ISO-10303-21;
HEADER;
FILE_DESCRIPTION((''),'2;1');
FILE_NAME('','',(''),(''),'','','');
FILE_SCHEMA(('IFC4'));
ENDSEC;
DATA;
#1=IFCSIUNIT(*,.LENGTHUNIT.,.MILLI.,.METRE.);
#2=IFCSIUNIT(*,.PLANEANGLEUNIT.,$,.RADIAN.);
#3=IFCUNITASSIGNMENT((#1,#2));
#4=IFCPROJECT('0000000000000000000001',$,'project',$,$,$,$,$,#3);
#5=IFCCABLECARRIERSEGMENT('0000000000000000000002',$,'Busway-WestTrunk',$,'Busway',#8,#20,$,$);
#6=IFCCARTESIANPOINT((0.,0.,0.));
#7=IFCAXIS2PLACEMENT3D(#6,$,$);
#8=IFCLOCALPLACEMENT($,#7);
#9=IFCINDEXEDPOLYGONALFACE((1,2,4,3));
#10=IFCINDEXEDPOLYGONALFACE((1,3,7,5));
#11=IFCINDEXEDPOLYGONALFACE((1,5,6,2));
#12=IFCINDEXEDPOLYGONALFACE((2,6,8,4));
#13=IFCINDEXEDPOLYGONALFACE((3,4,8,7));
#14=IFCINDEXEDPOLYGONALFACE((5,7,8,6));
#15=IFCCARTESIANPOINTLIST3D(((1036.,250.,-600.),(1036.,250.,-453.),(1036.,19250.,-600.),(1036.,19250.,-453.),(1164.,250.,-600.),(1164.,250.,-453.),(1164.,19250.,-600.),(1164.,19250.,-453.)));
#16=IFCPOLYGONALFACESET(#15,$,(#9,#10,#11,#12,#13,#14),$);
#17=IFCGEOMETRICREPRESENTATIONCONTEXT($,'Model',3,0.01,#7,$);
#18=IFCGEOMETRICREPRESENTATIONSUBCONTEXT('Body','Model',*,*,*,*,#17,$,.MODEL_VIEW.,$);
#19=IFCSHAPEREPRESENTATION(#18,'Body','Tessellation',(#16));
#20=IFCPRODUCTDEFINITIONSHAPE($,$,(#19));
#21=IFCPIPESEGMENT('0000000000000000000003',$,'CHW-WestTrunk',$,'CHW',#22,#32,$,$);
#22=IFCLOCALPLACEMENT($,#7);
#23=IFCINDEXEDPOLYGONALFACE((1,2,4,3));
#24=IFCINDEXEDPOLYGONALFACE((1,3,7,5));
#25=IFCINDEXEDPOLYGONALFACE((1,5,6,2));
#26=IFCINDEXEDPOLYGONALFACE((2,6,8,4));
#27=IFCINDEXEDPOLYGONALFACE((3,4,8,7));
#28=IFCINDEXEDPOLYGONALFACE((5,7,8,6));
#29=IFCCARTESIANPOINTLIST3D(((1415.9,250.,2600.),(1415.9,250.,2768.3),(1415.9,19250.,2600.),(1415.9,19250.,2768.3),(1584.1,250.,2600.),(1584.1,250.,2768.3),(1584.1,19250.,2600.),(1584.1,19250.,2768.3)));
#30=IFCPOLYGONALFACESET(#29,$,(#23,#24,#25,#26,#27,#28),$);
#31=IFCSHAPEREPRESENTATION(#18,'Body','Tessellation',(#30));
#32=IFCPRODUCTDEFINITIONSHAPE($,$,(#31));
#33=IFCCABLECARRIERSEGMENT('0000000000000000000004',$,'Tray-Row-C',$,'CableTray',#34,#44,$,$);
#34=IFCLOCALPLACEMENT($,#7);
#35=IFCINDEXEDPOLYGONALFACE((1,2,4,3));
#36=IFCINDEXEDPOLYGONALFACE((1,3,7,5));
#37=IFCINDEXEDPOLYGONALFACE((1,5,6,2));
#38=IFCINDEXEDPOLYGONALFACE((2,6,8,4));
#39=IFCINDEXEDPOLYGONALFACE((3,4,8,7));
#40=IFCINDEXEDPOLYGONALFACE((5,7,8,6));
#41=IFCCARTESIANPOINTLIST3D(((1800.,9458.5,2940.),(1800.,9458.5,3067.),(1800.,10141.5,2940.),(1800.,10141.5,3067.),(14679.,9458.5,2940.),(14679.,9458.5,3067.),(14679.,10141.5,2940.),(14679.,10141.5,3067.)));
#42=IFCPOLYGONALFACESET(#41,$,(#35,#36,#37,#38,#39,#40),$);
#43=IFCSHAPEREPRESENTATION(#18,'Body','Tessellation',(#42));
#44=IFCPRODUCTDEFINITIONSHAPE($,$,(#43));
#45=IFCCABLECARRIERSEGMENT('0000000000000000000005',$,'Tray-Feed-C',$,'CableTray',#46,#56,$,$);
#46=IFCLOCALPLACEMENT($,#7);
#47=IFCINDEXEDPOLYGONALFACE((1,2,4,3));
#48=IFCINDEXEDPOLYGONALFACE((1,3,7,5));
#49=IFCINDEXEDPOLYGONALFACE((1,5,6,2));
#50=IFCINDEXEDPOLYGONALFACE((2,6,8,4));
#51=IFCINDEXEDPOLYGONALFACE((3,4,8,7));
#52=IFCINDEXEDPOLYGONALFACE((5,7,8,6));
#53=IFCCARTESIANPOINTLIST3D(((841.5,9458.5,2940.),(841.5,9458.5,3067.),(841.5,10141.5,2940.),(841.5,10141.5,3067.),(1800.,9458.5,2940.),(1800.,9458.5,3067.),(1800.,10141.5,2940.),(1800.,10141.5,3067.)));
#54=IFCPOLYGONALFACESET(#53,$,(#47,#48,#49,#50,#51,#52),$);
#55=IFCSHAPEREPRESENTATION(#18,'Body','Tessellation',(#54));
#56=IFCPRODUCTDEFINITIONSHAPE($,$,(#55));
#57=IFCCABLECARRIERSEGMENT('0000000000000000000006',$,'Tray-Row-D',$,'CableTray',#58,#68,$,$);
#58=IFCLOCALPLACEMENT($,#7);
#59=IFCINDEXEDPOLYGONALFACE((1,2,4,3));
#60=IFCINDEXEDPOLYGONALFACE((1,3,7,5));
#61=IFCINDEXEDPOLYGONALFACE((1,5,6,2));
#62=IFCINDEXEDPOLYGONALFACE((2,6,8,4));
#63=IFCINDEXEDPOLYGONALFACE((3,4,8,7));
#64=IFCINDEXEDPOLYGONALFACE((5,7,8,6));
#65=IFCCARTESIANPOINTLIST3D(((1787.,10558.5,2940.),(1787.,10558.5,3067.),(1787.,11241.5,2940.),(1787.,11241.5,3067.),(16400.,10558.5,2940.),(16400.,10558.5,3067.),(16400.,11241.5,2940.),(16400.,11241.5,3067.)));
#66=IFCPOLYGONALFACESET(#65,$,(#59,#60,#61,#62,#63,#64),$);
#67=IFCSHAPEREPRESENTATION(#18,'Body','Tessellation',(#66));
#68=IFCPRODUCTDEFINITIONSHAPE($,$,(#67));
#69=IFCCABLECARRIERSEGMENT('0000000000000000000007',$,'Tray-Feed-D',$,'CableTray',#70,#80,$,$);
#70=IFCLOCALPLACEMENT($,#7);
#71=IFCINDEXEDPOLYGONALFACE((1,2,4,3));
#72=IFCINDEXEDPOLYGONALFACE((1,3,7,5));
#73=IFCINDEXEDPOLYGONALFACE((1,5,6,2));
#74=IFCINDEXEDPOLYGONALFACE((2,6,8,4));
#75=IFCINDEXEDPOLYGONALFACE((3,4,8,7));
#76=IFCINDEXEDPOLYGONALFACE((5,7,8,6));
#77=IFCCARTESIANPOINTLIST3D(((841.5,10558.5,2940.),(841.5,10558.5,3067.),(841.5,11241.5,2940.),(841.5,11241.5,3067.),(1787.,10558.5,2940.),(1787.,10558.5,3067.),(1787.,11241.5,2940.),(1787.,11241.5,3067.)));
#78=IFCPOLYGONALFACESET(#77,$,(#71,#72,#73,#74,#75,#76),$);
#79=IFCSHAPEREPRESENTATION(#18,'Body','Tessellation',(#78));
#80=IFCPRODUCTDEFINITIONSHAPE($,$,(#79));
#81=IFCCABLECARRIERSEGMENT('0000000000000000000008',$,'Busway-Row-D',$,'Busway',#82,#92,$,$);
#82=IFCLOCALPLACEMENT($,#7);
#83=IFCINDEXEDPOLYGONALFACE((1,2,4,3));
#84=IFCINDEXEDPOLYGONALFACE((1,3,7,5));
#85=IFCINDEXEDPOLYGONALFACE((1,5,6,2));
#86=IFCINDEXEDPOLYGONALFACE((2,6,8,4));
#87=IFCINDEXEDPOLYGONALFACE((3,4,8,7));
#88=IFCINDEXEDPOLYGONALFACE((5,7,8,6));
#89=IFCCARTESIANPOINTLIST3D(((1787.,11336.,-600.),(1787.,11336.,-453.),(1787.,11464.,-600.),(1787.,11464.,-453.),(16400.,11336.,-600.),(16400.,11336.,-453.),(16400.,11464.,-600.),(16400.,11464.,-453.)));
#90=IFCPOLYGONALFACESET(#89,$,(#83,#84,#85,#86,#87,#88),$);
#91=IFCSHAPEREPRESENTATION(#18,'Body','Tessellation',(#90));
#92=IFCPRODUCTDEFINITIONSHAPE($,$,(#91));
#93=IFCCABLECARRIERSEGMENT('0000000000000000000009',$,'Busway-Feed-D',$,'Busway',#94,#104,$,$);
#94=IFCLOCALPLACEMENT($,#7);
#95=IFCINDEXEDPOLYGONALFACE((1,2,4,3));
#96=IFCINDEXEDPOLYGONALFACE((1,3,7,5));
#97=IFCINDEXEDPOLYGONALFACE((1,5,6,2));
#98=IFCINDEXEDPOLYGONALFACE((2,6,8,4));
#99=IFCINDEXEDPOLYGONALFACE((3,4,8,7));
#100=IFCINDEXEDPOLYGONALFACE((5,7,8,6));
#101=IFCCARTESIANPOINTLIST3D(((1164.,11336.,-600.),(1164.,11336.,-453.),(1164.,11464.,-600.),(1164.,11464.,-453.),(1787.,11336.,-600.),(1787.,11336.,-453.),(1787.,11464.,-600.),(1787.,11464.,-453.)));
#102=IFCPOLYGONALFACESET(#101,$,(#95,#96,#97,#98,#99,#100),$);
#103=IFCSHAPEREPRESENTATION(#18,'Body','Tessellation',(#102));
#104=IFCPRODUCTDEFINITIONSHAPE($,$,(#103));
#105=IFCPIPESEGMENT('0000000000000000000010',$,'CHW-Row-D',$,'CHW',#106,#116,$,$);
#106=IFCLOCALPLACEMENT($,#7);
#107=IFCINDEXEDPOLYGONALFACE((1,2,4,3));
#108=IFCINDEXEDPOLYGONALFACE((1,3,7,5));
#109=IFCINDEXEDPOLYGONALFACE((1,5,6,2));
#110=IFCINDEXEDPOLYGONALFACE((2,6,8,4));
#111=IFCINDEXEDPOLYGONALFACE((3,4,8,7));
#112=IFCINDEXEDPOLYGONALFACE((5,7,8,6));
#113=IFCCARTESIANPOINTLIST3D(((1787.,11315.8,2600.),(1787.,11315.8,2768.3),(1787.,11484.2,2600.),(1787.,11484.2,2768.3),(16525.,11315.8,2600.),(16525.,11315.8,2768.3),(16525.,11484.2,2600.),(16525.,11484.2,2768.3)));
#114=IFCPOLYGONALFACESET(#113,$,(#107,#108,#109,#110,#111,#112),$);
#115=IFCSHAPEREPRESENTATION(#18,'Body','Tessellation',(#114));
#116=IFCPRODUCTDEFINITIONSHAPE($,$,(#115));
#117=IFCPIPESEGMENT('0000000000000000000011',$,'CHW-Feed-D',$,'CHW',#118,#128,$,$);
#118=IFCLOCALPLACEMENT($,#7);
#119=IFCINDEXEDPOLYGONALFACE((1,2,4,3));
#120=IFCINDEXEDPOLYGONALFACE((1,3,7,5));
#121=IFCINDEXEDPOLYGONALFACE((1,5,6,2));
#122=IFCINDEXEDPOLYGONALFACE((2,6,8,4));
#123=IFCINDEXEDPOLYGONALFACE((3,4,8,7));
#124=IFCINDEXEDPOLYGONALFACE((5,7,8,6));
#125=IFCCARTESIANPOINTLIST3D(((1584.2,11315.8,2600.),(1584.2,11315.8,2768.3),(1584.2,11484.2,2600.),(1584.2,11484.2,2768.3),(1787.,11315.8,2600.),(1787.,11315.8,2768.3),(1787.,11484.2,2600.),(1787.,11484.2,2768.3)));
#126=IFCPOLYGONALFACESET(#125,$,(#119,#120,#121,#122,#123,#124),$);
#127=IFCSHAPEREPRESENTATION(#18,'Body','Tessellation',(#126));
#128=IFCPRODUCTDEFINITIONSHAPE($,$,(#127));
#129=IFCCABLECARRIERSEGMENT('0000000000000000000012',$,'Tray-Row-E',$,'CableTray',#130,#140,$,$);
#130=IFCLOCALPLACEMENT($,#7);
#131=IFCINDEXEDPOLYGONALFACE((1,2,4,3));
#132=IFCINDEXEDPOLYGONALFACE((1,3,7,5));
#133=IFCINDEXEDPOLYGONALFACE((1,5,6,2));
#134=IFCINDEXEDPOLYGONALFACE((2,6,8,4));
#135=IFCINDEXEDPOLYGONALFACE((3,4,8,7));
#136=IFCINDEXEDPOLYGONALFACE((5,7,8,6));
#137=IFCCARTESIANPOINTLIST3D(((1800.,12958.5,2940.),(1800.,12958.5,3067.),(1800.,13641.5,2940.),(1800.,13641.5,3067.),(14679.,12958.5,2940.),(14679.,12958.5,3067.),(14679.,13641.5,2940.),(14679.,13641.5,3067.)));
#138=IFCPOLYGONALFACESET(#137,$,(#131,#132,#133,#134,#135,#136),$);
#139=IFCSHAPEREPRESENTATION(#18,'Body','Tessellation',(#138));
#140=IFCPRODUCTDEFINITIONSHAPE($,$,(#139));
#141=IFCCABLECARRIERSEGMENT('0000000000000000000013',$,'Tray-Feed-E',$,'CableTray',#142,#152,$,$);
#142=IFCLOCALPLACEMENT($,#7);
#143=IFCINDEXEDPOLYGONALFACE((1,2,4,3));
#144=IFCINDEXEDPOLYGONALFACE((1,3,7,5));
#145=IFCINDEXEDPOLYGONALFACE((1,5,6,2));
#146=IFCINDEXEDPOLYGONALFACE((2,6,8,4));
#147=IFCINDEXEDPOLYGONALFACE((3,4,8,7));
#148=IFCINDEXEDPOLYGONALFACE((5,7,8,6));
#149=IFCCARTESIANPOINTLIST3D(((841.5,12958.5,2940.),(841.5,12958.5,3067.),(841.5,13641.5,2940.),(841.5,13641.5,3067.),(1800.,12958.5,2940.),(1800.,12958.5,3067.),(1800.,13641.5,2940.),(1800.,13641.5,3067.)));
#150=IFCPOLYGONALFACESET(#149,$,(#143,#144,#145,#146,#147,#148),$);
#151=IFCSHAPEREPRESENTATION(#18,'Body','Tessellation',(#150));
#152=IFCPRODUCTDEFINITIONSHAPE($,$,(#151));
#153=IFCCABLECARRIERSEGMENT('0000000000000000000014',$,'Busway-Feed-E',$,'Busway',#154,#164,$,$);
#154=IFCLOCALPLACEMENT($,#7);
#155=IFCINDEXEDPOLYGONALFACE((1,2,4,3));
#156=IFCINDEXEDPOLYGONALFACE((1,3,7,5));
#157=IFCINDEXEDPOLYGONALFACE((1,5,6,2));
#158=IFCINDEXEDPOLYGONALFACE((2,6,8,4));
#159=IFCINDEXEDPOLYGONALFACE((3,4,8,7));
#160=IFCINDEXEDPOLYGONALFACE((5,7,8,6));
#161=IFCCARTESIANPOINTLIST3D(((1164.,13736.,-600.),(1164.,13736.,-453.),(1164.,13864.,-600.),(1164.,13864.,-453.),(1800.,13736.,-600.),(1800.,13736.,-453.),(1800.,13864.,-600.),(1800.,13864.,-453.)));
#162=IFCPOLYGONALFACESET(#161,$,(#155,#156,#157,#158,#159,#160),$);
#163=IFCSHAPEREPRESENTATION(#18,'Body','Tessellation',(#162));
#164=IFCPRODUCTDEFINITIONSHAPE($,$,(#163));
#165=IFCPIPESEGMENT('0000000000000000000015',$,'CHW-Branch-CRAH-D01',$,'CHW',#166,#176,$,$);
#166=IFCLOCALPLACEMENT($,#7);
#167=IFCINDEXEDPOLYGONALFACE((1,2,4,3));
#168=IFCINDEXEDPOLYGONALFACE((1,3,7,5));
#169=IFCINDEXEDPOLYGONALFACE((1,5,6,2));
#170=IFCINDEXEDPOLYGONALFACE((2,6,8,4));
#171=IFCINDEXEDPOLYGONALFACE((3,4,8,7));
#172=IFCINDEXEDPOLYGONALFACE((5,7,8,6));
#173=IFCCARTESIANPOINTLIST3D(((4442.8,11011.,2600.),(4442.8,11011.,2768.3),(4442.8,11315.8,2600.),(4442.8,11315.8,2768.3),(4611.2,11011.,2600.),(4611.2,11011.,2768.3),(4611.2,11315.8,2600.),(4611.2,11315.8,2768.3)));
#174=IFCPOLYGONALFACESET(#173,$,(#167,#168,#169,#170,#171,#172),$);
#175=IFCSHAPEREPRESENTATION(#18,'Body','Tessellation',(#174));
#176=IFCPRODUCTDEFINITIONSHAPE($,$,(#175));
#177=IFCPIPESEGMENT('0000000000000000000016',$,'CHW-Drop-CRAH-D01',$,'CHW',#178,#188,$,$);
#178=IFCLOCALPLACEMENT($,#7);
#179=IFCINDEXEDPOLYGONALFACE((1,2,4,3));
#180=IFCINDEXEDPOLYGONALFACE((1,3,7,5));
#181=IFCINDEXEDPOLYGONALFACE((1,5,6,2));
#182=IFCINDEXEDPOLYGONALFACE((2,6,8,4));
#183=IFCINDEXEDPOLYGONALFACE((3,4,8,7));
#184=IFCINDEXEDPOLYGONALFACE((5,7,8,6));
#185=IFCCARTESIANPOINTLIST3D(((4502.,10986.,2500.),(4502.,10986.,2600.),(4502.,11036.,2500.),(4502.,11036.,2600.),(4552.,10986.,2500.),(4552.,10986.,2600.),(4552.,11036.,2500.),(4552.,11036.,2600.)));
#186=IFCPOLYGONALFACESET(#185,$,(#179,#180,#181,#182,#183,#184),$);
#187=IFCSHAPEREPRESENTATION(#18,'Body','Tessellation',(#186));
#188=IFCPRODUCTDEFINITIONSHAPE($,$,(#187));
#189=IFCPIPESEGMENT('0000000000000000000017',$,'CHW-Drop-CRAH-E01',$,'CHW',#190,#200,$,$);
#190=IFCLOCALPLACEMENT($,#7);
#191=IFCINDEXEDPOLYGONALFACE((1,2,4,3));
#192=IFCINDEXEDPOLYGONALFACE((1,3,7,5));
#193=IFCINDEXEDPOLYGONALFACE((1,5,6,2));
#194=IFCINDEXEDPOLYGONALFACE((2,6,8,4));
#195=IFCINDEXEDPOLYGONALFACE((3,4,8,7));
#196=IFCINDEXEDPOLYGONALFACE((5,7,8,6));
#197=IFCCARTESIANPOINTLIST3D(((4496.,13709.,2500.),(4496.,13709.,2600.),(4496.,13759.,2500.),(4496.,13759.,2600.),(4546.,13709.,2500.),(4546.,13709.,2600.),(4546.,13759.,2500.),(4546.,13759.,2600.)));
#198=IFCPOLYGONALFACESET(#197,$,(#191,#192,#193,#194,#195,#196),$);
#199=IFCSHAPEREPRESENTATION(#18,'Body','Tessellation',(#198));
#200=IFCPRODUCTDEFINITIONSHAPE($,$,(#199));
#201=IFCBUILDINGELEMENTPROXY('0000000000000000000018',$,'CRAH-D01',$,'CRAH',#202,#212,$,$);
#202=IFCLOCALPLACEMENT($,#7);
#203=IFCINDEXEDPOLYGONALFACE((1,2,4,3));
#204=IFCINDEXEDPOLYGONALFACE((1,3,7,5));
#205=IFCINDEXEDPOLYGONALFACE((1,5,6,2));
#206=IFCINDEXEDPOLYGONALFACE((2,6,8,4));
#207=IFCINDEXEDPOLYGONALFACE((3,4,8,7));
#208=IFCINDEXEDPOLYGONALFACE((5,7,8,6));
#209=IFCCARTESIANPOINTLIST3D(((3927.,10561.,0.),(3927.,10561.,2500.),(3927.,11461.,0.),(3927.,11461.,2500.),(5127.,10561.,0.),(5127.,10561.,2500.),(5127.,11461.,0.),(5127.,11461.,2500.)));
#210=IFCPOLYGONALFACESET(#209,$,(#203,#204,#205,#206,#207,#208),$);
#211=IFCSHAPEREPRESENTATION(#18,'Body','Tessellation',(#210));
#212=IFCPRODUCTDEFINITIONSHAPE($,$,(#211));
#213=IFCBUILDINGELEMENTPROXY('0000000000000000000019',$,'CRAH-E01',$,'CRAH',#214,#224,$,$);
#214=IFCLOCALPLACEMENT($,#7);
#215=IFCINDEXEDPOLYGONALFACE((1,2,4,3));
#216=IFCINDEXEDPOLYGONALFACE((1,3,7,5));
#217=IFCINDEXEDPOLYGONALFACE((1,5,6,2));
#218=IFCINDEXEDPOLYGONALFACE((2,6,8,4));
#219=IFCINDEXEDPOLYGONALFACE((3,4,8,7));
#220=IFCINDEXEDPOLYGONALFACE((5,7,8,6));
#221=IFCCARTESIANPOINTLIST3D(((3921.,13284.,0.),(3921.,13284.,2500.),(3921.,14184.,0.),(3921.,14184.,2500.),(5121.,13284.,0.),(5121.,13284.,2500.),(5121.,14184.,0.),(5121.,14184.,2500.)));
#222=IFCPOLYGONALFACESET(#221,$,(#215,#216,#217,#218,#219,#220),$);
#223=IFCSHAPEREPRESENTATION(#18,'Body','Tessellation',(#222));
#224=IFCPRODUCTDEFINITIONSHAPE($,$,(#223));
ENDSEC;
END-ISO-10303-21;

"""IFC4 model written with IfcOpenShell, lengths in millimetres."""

from ifc_helpers import new_model, si_unit, frame, origin, place, context, subcontext, project, rectangle, extrude, element, save


model = new_model("IFC4")

# Units and contexts
model_context = context("Model", 3, precision=0.01, world=origin())
body_context = subcontext(model_context, "Body", "Model", "MODEL_VIEW")
ifc_project = project(units=[si_unit("LENGTHUNIT", "METRE", prefix="MILLI"), si_unit("PLANEANGLEUNIT", "RADIAN")])

# Cable carrier segment
placement = place(None, origin())
cable_carrier_segment_1_placement = place(placement, frame((1100.0, 9750.0, -600.0)))
element("IfcCableCarrierSegment", 1, at=cable_carrier_segment_1_placement, Name="Busway-WestTrunk", ObjectType="Busway", context=body_context, shape_type="SweptSolid", body=[
    extrude(rectangle(XDim=128.0, YDim=19000.0), origin(), (0.0, 0.0, 1.0), 147.0),
])

# Pipe segment
pipe_segment_1_placement = place(placement, frame((1500.0, 9750.0, 2600.0)))
element("IfcPipeSegment", 2, at=pipe_segment_1_placement, Name="CHW-WestTrunk", ObjectType="CHW", context=body_context, shape_type="SweptSolid", body=[
    extrude(rectangle(XDim=168.3, YDim=19000.0), origin(), (0.0, 0.0, 1.0), 168.3),
])

# Cable carrier segments
cable_carrier_segment_2_placement = place(placement, frame((8239.5, 9800.0, 2940.0)))
element("IfcCableCarrierSegment", 3, at=cable_carrier_segment_2_placement, Name="Tray-Row-C", ObjectType="CableTray", context=body_context, shape_type="SweptSolid", body=[
    extrude(rectangle(XDim=12879.0, YDim=683.0), origin(), (0.0, 0.0, 1.0), 127.0),
])
cable_carrier_segment_3_placement = place(placement, frame((1320.8, 9800.0, 2940.0)))
element("IfcCableCarrierSegment", 4, at=cable_carrier_segment_3_placement, Name="Tray-Feed-C", ObjectType="CableTray", context=body_context, shape_type="SweptSolid", body=[
    extrude(rectangle(XDim=958.5, YDim=683.0), origin(), (0.0, 0.0, 1.0), 127.0),
])
cable_carrier_segment_4_placement = place(placement, frame((9093.5, 10900.0, 2940.0)))
element("IfcCableCarrierSegment", 5, at=cable_carrier_segment_4_placement, Name="Tray-Row-D", ObjectType="CableTray", context=body_context, shape_type="SweptSolid", body=[
    extrude(rectangle(XDim=14613.0, YDim=683.0), origin(), (0.0, 0.0, 1.0), 127.0),
])
cable_carrier_segment_5_placement = place(placement, frame((1314.2, 10900.0, 2940.0)))
element("IfcCableCarrierSegment", 6, at=cable_carrier_segment_5_placement, Name="Tray-Feed-D", ObjectType="CableTray", context=body_context, shape_type="SweptSolid", body=[
    extrude(rectangle(XDim=945.5, YDim=683.0), origin(), (0.0, 0.0, 1.0), 127.0),
])
cable_carrier_segment_6_placement = place(placement, frame((9093.5, 11400.0, -600.0)))
element("IfcCableCarrierSegment", 7, at=cable_carrier_segment_6_placement, Name="Busway-Row-D", ObjectType="Busway", context=body_context, shape_type="SweptSolid", body=[
    extrude(rectangle(XDim=14613.0, YDim=128.0), origin(), (0.0, 0.0, 1.0), 147.0),
])
cable_carrier_segment_7_placement = place(placement, frame((1475.5, 11400.0, -600.0)))
element("IfcCableCarrierSegment", 8, at=cable_carrier_segment_7_placement, Name="Busway-Feed-D", ObjectType="Busway", context=body_context, shape_type="SweptSolid", body=[
    extrude(rectangle(XDim=623.0, YDim=128.0), origin(), (0.0, 0.0, 1.0), 147.0),
])

# Pipe segments
pipe_segment_2_placement = place(placement, frame((9156.0, 11400.0, 2600.0)))
element("IfcPipeSegment", 9, at=pipe_segment_2_placement, Name="CHW-Row-D", ObjectType="CHW", context=body_context, shape_type="SweptSolid", body=[
    extrude(rectangle(XDim=14738.0, YDim=168.3), origin(), (0.0, 0.0, 1.0), 168.3),
])
pipe_segment_3_placement = place(placement, frame((1685.6, 11400.0, 2600.0)))
element("IfcPipeSegment", 10, at=pipe_segment_3_placement, Name="CHW-Feed-D", ObjectType="CHW", context=body_context, shape_type="SweptSolid", body=[
    extrude(rectangle(XDim=202.8, YDim=168.3), origin(), (0.0, 0.0, 1.0), 168.3),
])

# Cable carrier segments
cable_carrier_segment_8_placement = place(placement, frame((8239.5, 13300.0, 2940.0)))
element("IfcCableCarrierSegment", 11, at=cable_carrier_segment_8_placement, Name="Tray-Row-E", ObjectType="CableTray", context=body_context, shape_type="SweptSolid", body=[
    extrude(rectangle(XDim=12879.0, YDim=683.0), origin(), (0.0, 0.0, 1.0), 127.0),
])
cable_carrier_segment_9_placement = place(placement, frame((1320.8, 13300.0, 2940.0)))
element("IfcCableCarrierSegment", 12, at=cable_carrier_segment_9_placement, Name="Tray-Feed-E", ObjectType="CableTray", context=body_context, shape_type="SweptSolid", body=[
    extrude(rectangle(XDim=958.5, YDim=683.0), origin(), (0.0, 0.0, 1.0), 127.0),
])
cable_carrier_segment_10_placement = place(placement, frame((1482.0, 13800.0, -600.0)))
element("IfcCableCarrierSegment", 13, at=cable_carrier_segment_10_placement, Name="Busway-Feed-E", ObjectType="Busway", context=body_context, shape_type="SweptSolid", body=[
    extrude(rectangle(XDim=636.0, YDim=128.0), origin(), (0.0, 0.0, 1.0), 147.0),
])

# Pipe segments
pipe_segment_4_placement = place(placement, frame((4527.0, 11163.4, 2600.0)))
element("IfcPipeSegment", 14, at=pipe_segment_4_placement, Name="CHW-Branch-CRAH-D01", ObjectType="CHW", context=body_context, shape_type="SweptSolid", body=[
    extrude(rectangle(XDim=168.3, YDim=304.9), origin(), (0.0, 0.0, 1.0), 168.3),
])
for number, where, name in (
    (15, (4527.0, 11011.0, 2500.0), "CHW-Drop-CRAH-D01"),
    (16, (4521.0, 13734.0, 2500.0), "CHW-Drop-CRAH-E01"),
):
    element("IfcPipeSegment", number, at=place(placement, frame(where)), Name=name, ObjectType="CHW", context=body_context, shape_type="SweptSolid", body=[
        extrude(rectangle(XDim=50.0, YDim=50.0), origin(), (0.0, 0.0, 1.0), 100.0),
    ])

# Building element proxies
for number, where, name in (
    (17, (4527.0, 11011.0, 0.0), "CRAH-D01"),
    (18, (4521.0, 13734.0, 0.0), "CRAH-E01"),
):
    element("IfcBuildingElementProxy", number, at=place(placement, frame(where)), Name=name, ObjectType="CRAH", context=body_context, shape_type="SweptSolid", body=[
        extrude(rectangle(XDim=1200.0, YDim=900.0), origin(), (0.0, 0.0, 1.0), 2500.0),
    ])

save(model, "model.ifc")
